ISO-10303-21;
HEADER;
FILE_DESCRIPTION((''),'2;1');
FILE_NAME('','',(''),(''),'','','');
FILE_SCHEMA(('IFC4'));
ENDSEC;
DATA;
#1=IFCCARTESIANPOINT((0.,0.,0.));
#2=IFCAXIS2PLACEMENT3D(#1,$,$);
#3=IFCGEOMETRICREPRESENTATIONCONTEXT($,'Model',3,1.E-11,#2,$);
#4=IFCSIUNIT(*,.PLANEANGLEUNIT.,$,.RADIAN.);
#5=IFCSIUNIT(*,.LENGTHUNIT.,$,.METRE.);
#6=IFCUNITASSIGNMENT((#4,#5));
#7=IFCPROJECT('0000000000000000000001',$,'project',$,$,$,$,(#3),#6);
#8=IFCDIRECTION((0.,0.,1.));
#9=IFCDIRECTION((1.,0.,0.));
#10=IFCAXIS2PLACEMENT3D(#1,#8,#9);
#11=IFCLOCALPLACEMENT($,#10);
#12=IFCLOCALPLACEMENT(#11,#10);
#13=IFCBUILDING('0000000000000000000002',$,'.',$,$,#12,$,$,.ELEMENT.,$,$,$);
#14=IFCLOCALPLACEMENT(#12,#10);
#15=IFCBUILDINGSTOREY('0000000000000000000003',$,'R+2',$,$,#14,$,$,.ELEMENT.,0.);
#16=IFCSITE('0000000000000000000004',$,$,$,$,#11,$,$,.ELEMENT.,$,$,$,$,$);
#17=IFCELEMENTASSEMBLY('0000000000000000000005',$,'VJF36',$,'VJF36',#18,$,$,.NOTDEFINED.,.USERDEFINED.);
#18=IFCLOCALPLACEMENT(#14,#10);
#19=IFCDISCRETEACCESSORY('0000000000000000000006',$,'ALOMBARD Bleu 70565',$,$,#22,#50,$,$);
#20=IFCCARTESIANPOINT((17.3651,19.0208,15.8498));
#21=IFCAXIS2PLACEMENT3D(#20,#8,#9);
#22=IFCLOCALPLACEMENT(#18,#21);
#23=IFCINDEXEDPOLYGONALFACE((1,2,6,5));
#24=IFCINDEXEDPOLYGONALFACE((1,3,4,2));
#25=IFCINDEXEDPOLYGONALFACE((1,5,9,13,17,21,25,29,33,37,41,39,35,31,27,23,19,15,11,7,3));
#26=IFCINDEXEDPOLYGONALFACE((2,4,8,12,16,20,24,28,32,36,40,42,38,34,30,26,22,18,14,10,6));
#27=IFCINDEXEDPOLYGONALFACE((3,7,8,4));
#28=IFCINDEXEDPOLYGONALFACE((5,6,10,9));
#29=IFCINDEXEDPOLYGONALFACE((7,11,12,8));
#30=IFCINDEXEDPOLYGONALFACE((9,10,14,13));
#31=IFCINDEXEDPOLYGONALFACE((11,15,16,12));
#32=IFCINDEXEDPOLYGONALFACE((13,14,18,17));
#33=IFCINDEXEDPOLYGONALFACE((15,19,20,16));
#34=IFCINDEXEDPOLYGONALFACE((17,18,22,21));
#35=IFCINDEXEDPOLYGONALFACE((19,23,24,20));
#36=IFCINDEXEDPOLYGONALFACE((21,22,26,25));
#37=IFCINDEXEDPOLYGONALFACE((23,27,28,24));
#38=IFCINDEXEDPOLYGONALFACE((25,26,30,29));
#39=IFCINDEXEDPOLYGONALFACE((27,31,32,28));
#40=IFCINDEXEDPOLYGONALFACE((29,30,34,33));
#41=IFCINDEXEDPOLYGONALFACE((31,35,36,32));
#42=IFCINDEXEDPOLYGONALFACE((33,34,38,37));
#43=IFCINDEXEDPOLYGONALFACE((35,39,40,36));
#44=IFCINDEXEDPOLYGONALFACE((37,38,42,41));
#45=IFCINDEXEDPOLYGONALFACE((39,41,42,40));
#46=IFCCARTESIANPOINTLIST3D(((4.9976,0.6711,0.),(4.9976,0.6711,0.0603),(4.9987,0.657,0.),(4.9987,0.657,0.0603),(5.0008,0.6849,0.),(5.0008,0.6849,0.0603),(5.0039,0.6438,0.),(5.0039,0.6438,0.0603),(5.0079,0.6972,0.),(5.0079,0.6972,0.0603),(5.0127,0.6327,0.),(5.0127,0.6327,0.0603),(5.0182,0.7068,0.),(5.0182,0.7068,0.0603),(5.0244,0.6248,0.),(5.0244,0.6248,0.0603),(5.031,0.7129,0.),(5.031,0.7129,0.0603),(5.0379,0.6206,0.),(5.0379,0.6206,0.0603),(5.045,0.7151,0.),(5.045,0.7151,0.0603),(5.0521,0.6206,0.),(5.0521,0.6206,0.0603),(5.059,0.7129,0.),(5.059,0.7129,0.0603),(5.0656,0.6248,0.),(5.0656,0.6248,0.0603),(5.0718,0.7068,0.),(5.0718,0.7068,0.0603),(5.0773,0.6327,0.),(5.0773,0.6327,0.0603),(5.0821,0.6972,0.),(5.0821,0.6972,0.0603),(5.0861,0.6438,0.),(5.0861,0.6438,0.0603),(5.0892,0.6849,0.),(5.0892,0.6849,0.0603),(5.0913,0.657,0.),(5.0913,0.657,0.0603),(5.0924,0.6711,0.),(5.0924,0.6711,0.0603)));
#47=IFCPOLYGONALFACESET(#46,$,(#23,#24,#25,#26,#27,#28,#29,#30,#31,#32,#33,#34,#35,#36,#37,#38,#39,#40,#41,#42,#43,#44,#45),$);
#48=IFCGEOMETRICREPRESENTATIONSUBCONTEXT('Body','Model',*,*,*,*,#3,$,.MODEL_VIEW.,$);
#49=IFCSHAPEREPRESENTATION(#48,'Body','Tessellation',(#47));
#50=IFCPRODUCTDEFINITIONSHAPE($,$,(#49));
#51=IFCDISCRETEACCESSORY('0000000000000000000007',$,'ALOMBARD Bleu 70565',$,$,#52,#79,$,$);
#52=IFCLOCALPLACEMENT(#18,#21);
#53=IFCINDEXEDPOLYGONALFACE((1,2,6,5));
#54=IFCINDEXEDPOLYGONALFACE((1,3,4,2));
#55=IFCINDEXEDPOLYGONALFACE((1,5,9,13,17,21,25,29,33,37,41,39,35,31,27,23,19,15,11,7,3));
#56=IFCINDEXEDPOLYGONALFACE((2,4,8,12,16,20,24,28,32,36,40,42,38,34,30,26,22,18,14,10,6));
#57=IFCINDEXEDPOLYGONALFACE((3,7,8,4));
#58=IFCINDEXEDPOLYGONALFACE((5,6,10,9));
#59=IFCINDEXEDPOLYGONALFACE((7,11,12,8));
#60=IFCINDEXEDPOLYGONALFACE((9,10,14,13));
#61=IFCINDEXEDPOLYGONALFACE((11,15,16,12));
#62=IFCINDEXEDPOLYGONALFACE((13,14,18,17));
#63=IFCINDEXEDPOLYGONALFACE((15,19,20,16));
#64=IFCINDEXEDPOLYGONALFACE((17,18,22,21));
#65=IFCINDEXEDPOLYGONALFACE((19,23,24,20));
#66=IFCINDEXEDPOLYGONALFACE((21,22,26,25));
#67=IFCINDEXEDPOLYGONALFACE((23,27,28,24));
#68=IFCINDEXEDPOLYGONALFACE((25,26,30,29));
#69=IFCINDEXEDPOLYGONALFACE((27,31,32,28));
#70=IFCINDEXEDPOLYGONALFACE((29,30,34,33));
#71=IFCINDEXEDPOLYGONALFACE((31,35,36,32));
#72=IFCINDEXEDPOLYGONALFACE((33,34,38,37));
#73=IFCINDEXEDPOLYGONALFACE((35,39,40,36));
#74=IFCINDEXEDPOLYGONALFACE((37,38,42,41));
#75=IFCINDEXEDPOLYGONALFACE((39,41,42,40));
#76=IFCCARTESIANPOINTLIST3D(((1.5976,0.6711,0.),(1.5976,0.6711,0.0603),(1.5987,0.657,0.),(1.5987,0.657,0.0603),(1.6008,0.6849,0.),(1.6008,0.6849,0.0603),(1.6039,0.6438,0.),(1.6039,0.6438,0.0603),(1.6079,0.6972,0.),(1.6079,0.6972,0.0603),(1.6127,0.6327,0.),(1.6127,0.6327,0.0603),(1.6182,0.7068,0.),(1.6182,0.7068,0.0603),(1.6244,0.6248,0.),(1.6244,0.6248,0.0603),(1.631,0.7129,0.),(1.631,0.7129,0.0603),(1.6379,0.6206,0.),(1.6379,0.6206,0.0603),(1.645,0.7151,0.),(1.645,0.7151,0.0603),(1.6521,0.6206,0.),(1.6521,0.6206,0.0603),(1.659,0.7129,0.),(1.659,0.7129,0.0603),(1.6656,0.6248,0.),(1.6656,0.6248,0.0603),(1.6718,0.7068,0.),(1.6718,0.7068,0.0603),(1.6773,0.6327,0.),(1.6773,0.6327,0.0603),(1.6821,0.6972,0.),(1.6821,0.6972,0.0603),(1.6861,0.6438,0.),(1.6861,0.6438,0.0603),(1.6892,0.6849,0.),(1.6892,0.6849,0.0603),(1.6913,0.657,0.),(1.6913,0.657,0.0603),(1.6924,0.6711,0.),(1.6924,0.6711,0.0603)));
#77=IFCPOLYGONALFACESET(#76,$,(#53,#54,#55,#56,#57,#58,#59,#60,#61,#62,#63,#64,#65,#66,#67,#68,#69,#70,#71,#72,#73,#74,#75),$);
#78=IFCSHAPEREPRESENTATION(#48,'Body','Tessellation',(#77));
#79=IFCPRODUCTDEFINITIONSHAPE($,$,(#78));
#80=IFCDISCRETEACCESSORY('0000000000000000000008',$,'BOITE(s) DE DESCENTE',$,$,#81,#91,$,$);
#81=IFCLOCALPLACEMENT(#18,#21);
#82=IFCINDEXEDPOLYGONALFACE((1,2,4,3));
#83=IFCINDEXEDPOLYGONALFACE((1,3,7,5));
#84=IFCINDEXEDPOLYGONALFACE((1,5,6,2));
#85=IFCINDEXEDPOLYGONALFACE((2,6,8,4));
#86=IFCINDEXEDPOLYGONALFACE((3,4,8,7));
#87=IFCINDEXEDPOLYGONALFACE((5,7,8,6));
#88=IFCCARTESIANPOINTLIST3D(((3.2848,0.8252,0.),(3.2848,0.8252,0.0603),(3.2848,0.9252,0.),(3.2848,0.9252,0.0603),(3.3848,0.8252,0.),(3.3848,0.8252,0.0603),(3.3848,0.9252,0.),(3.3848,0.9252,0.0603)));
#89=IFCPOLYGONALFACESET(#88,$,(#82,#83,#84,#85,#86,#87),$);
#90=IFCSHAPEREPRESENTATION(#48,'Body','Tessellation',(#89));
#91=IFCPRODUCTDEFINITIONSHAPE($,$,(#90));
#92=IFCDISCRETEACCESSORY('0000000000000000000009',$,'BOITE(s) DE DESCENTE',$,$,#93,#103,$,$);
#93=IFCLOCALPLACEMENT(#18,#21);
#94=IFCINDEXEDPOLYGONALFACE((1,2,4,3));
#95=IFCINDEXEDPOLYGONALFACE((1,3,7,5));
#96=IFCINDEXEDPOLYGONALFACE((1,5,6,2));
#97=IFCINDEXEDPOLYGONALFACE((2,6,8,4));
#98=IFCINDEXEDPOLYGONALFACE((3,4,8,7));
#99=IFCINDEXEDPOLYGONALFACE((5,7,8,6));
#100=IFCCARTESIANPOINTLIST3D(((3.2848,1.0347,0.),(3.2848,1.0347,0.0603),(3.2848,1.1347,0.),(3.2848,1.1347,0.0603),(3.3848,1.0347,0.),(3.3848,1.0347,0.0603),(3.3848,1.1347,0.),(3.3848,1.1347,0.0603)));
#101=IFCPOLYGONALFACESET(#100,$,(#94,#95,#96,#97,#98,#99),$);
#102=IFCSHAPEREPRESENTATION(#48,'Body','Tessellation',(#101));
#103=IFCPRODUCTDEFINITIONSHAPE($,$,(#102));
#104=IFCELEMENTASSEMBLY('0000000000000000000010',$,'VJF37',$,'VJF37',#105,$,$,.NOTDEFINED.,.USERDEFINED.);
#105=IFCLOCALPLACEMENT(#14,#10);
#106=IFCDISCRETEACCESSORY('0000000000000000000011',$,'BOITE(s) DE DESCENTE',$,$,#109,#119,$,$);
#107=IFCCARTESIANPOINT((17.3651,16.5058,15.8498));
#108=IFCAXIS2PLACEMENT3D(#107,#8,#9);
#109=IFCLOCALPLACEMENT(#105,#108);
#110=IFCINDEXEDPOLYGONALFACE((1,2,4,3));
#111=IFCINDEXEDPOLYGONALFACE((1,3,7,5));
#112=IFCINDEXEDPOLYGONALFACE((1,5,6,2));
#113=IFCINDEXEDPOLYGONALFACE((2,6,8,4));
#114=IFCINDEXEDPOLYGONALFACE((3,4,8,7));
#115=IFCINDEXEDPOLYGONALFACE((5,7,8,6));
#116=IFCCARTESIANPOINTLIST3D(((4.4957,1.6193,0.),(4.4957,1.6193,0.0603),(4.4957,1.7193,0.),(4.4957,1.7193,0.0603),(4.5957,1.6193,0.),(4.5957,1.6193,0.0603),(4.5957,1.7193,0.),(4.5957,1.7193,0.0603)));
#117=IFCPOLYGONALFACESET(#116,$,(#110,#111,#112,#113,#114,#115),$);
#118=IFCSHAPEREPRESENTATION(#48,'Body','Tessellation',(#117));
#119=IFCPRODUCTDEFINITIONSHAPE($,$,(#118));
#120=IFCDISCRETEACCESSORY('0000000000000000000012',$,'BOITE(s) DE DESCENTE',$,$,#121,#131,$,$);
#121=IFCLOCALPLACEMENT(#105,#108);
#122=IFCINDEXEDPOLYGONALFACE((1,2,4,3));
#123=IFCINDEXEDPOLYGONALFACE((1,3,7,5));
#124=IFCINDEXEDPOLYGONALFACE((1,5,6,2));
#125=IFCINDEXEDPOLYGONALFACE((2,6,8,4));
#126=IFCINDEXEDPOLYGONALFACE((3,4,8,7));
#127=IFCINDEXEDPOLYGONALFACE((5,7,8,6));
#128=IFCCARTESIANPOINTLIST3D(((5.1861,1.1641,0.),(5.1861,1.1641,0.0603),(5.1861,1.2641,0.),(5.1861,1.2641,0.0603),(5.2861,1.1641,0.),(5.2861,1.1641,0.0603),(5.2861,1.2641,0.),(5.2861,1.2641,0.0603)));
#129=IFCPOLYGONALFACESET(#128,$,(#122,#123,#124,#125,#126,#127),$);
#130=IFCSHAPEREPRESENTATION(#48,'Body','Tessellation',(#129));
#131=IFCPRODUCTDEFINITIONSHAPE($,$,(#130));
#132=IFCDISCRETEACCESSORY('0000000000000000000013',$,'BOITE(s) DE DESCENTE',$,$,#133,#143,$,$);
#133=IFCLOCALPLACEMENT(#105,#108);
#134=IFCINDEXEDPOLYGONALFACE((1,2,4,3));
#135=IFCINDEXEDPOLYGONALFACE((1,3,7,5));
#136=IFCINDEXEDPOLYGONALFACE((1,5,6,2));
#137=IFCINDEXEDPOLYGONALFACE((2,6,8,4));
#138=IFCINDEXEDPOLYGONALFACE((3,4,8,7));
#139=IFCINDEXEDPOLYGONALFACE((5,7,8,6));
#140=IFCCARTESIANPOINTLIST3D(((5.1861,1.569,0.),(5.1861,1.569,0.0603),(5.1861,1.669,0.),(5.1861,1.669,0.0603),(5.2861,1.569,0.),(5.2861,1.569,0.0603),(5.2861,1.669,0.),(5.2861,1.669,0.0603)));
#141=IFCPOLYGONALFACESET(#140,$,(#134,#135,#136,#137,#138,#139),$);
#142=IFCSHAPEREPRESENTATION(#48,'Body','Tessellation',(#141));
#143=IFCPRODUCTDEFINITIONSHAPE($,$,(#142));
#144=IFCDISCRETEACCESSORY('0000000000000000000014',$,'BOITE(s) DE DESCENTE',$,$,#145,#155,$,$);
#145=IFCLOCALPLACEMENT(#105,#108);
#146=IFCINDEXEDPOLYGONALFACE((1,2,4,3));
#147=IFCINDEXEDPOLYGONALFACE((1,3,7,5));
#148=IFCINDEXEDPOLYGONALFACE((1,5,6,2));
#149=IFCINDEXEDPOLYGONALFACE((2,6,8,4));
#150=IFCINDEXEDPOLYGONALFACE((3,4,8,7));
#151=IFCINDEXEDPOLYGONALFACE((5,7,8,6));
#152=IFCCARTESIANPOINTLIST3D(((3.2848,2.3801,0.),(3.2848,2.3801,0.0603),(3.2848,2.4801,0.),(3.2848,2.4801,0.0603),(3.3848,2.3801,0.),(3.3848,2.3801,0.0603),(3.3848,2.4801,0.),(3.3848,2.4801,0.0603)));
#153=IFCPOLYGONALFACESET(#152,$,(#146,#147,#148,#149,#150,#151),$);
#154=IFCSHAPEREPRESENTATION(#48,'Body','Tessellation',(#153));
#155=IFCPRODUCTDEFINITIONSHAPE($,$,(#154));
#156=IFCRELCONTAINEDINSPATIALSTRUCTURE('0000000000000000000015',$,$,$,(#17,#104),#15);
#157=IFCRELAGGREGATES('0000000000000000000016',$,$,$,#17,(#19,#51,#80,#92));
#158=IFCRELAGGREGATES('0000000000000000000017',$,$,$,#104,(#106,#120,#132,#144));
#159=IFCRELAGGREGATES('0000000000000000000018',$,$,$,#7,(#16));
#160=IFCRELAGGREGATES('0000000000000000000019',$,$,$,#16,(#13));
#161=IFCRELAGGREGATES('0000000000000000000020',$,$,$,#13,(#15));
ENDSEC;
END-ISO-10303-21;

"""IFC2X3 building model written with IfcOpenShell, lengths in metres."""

from ifc_helpers import new_model, si_unit, frame, frame_2d, origin, origin_with_axes, place, context, subcontext, project, spatial, polyline, circle, outline, extrude, element, aggregate, save


model = new_model("IFC2X3")

# Units and contexts
model_context = context("Model", 3, precision=1e-11, world=origin())
body_context = subcontext(model_context, "Body", "Model", "MODEL_VIEW")
ifc_project = project(units=[si_unit("PLANEANGLEUNIT", "RADIAN"), si_unit("LENGTHUNIT", "METRE")], contexts=[model_context])

# Site, building, storey
site_placement = place(None, origin_with_axes())
site = spatial("IfcSite", under=ifc_project, at=site_placement, CompositionType="ELEMENT")
building_placement = place(site_placement, origin_with_axes())
building = spatial("IfcBuilding", under=site, at=building_placement, Name=".", CompositionType="ELEMENT")
storey_placement = place(building_placement, origin_with_axes())
storey = spatial("IfcBuildingStorey", under=building, at=storey_placement, Name="R+2", CompositionType="ELEMENT", Elevation=0.0)

# Element assembly
assembly_1_placement = place(storey_placement, origin_with_axes())
assembly_1 = element("IfcElementAssembly", 1, at=assembly_1_placement, inside=storey, Name="VJF36", ObjectType="VJF36", AssemblyPlace="NOTDEFINED", PredefinedType="USERDEFINED")

# Discrete accessories
discrete_accessory_1_placement = place(assembly_1_placement, frame((17.3651, 19.0208, 15.8498), z_axis=(0.0, 0.0, 1.0), x_axis=(1.0, 0.0, 0.0)))
discrete_accessory_1 = element("IfcDiscreteAccessory", 2, at=discrete_accessory_1_placement, Name="ALOMBARD Bleu 70565", context=body_context, shape_type="SweptSolid", body=[
    extrude(circle(Radius=0.0475, at=frame_2d((0.6676, -5.045), x_axis=(1.0, 0.0))), frame((0.0, 0.0, 0.0), z_axis=(0.0, 0.0, 1.0), x_axis=(0.0, 1.0, 0.0)), (0.0, 0.0, 1.0), 0.0603),
])
discrete_accessory_2_placement = place(assembly_1_placement, frame((17.3651, 19.0208, 15.8498), z_axis=(0.0, 0.0, 1.0), x_axis=(1.0, 0.0, 0.0)))
discrete_accessory_2 = element("IfcDiscreteAccessory", 3, at=discrete_accessory_2_placement, Name="ALOMBARD Bleu 70565", context=body_context, shape_type="SweptSolid", body=[
    extrude(circle(Radius=0.0475, at=frame_2d((0.6676, -1.645), x_axis=(1.0, 0.0))), frame((0.0, 0.0, 0.0), z_axis=(0.0, 0.0, 1.0), x_axis=(0.0, 1.0, 0.0)), (0.0, 0.0, 1.0), 0.0603),
])
discrete_accessory_3_placement = place(assembly_1_placement, frame((17.3651, 19.0208, 15.8498), z_axis=(0.0, 0.0, 1.0), x_axis=(1.0, 0.0, 0.0)))
discrete_accessory_3 = element("IfcDiscreteAccessory", 4, at=discrete_accessory_3_placement, Name="BOITE(s) DE DESCENTE", context=body_context, shape_type="SweptSolid", body=[
    extrude(outline(polyline([(0.8252, -3.2848), (0.8252, -3.3848), (0.9252, -3.3848), (0.9252, -3.2848), (0.8252, -3.2848)])), frame((0.0, 0.0, 0.0), z_axis=(0.0, 0.0, 1.0), x_axis=(0.0, 1.0, 0.0)), (0.0, 0.0, 1.0), 0.0603),
])
discrete_accessory_4_placement = place(assembly_1_placement, frame((17.3651, 19.0208, 15.8498), z_axis=(0.0, 0.0, 1.0), x_axis=(1.0, 0.0, 0.0)))
discrete_accessory_4 = element("IfcDiscreteAccessory", 5, at=discrete_accessory_4_placement, Name="BOITE(s) DE DESCENTE", context=body_context, shape_type="SweptSolid", body=[
    extrude(outline(polyline([(1.0347, -3.2848), (1.0347, -3.3848), (1.1347, -3.3848), (1.1347, -3.2848), (1.0347, -3.2848)])), frame((0.0, 0.0, 0.0), z_axis=(0.0, 0.0, 1.0), x_axis=(0.0, 1.0, 0.0)), (0.0, 0.0, 1.0), 0.0603),
])
aggregate(assembly_1, [discrete_accessory_1, discrete_accessory_2, discrete_accessory_3, discrete_accessory_4])

# Element assembly, discrete accessories
assembly_2_placement = place(storey_placement, origin_with_axes())
assembly_2 = element("IfcElementAssembly", 6, at=assembly_2_placement, inside=storey, Name="VJF37", ObjectType="VJF37", AssemblyPlace="NOTDEFINED", PredefinedType="USERDEFINED")
discrete_accessory_5_placement = place(assembly_2_placement, frame((17.3651, 16.5058, 15.8498), z_axis=(0.0, 0.0, 1.0), x_axis=(1.0, 0.0, 0.0)))
discrete_accessory_5 = element("IfcDiscreteAccessory", 7, at=discrete_accessory_5_placement, Name="BOITE(s) DE DESCENTE", context=body_context, shape_type="SweptSolid", body=[
    extrude(outline(polyline([(1.6193, -4.4957), (1.6193, -4.5957), (1.7193, -4.5957), (1.7193, -4.4957), (1.6193, -4.4957)])), frame((0.0, 0.0, 0.0), z_axis=(0.0, 0.0, 1.0), x_axis=(0.0, 1.0, 0.0)), (0.0, 0.0, 1.0), 0.0603),
])
discrete_accessory_6_placement = place(assembly_2_placement, frame((17.3651, 16.5058, 15.8498), z_axis=(0.0, 0.0, 1.0), x_axis=(1.0, 0.0, 0.0)))
discrete_accessory_6 = element("IfcDiscreteAccessory", 8, at=discrete_accessory_6_placement, Name="BOITE(s) DE DESCENTE", context=body_context, shape_type="SweptSolid", body=[
    extrude(outline(polyline([(1.1641, -5.1861), (1.1641, -5.2861), (1.2641, -5.2861), (1.2641, -5.1861), (1.1641, -5.1861)])), frame((0.0, 0.0, 0.0), z_axis=(0.0, 0.0, 1.0), x_axis=(0.0, 1.0, 0.0)), (0.0, 0.0, 1.0), 0.0603),
])
discrete_accessory_7_placement = place(assembly_2_placement, frame((17.3651, 16.5058, 15.8498), z_axis=(0.0, 0.0, 1.0), x_axis=(1.0, 0.0, 0.0)))
discrete_accessory_7 = element("IfcDiscreteAccessory", 9, at=discrete_accessory_7_placement, Name="BOITE(s) DE DESCENTE", context=body_context, shape_type="SweptSolid", body=[
    extrude(outline(polyline([(1.569, -5.1861), (1.569, -5.2861), (1.669, -5.2861), (1.669, -5.1861), (1.569, -5.1861)])), frame((0.0, 0.0, 0.0), z_axis=(0.0, 0.0, 1.0), x_axis=(0.0, 1.0, 0.0)), (0.0, 0.0, 1.0), 0.0603),
])
discrete_accessory_8_placement = place(assembly_2_placement, frame((17.3651, 16.5058, 15.8498), z_axis=(0.0, 0.0, 1.0), x_axis=(1.0, 0.0, 0.0)))
discrete_accessory_8 = element("IfcDiscreteAccessory", 10, at=discrete_accessory_8_placement, Name="BOITE(s) DE DESCENTE", context=body_context, shape_type="SweptSolid", body=[
    extrude(outline(polyline([(2.3801, -3.2848), (2.3801, -3.3848), (2.4801, -3.3848), (2.4801, -3.2848), (2.3801, -3.2848)])), frame((0.0, 0.0, 0.0), z_axis=(0.0, 0.0, 1.0), x_axis=(0.0, 1.0, 0.0)), (0.0, 0.0, 1.0), 0.0603),
])
aggregate(assembly_2, [discrete_accessory_5, discrete_accessory_6, discrete_accessory_7, discrete_accessory_8])

save(model, "model.ifc")
